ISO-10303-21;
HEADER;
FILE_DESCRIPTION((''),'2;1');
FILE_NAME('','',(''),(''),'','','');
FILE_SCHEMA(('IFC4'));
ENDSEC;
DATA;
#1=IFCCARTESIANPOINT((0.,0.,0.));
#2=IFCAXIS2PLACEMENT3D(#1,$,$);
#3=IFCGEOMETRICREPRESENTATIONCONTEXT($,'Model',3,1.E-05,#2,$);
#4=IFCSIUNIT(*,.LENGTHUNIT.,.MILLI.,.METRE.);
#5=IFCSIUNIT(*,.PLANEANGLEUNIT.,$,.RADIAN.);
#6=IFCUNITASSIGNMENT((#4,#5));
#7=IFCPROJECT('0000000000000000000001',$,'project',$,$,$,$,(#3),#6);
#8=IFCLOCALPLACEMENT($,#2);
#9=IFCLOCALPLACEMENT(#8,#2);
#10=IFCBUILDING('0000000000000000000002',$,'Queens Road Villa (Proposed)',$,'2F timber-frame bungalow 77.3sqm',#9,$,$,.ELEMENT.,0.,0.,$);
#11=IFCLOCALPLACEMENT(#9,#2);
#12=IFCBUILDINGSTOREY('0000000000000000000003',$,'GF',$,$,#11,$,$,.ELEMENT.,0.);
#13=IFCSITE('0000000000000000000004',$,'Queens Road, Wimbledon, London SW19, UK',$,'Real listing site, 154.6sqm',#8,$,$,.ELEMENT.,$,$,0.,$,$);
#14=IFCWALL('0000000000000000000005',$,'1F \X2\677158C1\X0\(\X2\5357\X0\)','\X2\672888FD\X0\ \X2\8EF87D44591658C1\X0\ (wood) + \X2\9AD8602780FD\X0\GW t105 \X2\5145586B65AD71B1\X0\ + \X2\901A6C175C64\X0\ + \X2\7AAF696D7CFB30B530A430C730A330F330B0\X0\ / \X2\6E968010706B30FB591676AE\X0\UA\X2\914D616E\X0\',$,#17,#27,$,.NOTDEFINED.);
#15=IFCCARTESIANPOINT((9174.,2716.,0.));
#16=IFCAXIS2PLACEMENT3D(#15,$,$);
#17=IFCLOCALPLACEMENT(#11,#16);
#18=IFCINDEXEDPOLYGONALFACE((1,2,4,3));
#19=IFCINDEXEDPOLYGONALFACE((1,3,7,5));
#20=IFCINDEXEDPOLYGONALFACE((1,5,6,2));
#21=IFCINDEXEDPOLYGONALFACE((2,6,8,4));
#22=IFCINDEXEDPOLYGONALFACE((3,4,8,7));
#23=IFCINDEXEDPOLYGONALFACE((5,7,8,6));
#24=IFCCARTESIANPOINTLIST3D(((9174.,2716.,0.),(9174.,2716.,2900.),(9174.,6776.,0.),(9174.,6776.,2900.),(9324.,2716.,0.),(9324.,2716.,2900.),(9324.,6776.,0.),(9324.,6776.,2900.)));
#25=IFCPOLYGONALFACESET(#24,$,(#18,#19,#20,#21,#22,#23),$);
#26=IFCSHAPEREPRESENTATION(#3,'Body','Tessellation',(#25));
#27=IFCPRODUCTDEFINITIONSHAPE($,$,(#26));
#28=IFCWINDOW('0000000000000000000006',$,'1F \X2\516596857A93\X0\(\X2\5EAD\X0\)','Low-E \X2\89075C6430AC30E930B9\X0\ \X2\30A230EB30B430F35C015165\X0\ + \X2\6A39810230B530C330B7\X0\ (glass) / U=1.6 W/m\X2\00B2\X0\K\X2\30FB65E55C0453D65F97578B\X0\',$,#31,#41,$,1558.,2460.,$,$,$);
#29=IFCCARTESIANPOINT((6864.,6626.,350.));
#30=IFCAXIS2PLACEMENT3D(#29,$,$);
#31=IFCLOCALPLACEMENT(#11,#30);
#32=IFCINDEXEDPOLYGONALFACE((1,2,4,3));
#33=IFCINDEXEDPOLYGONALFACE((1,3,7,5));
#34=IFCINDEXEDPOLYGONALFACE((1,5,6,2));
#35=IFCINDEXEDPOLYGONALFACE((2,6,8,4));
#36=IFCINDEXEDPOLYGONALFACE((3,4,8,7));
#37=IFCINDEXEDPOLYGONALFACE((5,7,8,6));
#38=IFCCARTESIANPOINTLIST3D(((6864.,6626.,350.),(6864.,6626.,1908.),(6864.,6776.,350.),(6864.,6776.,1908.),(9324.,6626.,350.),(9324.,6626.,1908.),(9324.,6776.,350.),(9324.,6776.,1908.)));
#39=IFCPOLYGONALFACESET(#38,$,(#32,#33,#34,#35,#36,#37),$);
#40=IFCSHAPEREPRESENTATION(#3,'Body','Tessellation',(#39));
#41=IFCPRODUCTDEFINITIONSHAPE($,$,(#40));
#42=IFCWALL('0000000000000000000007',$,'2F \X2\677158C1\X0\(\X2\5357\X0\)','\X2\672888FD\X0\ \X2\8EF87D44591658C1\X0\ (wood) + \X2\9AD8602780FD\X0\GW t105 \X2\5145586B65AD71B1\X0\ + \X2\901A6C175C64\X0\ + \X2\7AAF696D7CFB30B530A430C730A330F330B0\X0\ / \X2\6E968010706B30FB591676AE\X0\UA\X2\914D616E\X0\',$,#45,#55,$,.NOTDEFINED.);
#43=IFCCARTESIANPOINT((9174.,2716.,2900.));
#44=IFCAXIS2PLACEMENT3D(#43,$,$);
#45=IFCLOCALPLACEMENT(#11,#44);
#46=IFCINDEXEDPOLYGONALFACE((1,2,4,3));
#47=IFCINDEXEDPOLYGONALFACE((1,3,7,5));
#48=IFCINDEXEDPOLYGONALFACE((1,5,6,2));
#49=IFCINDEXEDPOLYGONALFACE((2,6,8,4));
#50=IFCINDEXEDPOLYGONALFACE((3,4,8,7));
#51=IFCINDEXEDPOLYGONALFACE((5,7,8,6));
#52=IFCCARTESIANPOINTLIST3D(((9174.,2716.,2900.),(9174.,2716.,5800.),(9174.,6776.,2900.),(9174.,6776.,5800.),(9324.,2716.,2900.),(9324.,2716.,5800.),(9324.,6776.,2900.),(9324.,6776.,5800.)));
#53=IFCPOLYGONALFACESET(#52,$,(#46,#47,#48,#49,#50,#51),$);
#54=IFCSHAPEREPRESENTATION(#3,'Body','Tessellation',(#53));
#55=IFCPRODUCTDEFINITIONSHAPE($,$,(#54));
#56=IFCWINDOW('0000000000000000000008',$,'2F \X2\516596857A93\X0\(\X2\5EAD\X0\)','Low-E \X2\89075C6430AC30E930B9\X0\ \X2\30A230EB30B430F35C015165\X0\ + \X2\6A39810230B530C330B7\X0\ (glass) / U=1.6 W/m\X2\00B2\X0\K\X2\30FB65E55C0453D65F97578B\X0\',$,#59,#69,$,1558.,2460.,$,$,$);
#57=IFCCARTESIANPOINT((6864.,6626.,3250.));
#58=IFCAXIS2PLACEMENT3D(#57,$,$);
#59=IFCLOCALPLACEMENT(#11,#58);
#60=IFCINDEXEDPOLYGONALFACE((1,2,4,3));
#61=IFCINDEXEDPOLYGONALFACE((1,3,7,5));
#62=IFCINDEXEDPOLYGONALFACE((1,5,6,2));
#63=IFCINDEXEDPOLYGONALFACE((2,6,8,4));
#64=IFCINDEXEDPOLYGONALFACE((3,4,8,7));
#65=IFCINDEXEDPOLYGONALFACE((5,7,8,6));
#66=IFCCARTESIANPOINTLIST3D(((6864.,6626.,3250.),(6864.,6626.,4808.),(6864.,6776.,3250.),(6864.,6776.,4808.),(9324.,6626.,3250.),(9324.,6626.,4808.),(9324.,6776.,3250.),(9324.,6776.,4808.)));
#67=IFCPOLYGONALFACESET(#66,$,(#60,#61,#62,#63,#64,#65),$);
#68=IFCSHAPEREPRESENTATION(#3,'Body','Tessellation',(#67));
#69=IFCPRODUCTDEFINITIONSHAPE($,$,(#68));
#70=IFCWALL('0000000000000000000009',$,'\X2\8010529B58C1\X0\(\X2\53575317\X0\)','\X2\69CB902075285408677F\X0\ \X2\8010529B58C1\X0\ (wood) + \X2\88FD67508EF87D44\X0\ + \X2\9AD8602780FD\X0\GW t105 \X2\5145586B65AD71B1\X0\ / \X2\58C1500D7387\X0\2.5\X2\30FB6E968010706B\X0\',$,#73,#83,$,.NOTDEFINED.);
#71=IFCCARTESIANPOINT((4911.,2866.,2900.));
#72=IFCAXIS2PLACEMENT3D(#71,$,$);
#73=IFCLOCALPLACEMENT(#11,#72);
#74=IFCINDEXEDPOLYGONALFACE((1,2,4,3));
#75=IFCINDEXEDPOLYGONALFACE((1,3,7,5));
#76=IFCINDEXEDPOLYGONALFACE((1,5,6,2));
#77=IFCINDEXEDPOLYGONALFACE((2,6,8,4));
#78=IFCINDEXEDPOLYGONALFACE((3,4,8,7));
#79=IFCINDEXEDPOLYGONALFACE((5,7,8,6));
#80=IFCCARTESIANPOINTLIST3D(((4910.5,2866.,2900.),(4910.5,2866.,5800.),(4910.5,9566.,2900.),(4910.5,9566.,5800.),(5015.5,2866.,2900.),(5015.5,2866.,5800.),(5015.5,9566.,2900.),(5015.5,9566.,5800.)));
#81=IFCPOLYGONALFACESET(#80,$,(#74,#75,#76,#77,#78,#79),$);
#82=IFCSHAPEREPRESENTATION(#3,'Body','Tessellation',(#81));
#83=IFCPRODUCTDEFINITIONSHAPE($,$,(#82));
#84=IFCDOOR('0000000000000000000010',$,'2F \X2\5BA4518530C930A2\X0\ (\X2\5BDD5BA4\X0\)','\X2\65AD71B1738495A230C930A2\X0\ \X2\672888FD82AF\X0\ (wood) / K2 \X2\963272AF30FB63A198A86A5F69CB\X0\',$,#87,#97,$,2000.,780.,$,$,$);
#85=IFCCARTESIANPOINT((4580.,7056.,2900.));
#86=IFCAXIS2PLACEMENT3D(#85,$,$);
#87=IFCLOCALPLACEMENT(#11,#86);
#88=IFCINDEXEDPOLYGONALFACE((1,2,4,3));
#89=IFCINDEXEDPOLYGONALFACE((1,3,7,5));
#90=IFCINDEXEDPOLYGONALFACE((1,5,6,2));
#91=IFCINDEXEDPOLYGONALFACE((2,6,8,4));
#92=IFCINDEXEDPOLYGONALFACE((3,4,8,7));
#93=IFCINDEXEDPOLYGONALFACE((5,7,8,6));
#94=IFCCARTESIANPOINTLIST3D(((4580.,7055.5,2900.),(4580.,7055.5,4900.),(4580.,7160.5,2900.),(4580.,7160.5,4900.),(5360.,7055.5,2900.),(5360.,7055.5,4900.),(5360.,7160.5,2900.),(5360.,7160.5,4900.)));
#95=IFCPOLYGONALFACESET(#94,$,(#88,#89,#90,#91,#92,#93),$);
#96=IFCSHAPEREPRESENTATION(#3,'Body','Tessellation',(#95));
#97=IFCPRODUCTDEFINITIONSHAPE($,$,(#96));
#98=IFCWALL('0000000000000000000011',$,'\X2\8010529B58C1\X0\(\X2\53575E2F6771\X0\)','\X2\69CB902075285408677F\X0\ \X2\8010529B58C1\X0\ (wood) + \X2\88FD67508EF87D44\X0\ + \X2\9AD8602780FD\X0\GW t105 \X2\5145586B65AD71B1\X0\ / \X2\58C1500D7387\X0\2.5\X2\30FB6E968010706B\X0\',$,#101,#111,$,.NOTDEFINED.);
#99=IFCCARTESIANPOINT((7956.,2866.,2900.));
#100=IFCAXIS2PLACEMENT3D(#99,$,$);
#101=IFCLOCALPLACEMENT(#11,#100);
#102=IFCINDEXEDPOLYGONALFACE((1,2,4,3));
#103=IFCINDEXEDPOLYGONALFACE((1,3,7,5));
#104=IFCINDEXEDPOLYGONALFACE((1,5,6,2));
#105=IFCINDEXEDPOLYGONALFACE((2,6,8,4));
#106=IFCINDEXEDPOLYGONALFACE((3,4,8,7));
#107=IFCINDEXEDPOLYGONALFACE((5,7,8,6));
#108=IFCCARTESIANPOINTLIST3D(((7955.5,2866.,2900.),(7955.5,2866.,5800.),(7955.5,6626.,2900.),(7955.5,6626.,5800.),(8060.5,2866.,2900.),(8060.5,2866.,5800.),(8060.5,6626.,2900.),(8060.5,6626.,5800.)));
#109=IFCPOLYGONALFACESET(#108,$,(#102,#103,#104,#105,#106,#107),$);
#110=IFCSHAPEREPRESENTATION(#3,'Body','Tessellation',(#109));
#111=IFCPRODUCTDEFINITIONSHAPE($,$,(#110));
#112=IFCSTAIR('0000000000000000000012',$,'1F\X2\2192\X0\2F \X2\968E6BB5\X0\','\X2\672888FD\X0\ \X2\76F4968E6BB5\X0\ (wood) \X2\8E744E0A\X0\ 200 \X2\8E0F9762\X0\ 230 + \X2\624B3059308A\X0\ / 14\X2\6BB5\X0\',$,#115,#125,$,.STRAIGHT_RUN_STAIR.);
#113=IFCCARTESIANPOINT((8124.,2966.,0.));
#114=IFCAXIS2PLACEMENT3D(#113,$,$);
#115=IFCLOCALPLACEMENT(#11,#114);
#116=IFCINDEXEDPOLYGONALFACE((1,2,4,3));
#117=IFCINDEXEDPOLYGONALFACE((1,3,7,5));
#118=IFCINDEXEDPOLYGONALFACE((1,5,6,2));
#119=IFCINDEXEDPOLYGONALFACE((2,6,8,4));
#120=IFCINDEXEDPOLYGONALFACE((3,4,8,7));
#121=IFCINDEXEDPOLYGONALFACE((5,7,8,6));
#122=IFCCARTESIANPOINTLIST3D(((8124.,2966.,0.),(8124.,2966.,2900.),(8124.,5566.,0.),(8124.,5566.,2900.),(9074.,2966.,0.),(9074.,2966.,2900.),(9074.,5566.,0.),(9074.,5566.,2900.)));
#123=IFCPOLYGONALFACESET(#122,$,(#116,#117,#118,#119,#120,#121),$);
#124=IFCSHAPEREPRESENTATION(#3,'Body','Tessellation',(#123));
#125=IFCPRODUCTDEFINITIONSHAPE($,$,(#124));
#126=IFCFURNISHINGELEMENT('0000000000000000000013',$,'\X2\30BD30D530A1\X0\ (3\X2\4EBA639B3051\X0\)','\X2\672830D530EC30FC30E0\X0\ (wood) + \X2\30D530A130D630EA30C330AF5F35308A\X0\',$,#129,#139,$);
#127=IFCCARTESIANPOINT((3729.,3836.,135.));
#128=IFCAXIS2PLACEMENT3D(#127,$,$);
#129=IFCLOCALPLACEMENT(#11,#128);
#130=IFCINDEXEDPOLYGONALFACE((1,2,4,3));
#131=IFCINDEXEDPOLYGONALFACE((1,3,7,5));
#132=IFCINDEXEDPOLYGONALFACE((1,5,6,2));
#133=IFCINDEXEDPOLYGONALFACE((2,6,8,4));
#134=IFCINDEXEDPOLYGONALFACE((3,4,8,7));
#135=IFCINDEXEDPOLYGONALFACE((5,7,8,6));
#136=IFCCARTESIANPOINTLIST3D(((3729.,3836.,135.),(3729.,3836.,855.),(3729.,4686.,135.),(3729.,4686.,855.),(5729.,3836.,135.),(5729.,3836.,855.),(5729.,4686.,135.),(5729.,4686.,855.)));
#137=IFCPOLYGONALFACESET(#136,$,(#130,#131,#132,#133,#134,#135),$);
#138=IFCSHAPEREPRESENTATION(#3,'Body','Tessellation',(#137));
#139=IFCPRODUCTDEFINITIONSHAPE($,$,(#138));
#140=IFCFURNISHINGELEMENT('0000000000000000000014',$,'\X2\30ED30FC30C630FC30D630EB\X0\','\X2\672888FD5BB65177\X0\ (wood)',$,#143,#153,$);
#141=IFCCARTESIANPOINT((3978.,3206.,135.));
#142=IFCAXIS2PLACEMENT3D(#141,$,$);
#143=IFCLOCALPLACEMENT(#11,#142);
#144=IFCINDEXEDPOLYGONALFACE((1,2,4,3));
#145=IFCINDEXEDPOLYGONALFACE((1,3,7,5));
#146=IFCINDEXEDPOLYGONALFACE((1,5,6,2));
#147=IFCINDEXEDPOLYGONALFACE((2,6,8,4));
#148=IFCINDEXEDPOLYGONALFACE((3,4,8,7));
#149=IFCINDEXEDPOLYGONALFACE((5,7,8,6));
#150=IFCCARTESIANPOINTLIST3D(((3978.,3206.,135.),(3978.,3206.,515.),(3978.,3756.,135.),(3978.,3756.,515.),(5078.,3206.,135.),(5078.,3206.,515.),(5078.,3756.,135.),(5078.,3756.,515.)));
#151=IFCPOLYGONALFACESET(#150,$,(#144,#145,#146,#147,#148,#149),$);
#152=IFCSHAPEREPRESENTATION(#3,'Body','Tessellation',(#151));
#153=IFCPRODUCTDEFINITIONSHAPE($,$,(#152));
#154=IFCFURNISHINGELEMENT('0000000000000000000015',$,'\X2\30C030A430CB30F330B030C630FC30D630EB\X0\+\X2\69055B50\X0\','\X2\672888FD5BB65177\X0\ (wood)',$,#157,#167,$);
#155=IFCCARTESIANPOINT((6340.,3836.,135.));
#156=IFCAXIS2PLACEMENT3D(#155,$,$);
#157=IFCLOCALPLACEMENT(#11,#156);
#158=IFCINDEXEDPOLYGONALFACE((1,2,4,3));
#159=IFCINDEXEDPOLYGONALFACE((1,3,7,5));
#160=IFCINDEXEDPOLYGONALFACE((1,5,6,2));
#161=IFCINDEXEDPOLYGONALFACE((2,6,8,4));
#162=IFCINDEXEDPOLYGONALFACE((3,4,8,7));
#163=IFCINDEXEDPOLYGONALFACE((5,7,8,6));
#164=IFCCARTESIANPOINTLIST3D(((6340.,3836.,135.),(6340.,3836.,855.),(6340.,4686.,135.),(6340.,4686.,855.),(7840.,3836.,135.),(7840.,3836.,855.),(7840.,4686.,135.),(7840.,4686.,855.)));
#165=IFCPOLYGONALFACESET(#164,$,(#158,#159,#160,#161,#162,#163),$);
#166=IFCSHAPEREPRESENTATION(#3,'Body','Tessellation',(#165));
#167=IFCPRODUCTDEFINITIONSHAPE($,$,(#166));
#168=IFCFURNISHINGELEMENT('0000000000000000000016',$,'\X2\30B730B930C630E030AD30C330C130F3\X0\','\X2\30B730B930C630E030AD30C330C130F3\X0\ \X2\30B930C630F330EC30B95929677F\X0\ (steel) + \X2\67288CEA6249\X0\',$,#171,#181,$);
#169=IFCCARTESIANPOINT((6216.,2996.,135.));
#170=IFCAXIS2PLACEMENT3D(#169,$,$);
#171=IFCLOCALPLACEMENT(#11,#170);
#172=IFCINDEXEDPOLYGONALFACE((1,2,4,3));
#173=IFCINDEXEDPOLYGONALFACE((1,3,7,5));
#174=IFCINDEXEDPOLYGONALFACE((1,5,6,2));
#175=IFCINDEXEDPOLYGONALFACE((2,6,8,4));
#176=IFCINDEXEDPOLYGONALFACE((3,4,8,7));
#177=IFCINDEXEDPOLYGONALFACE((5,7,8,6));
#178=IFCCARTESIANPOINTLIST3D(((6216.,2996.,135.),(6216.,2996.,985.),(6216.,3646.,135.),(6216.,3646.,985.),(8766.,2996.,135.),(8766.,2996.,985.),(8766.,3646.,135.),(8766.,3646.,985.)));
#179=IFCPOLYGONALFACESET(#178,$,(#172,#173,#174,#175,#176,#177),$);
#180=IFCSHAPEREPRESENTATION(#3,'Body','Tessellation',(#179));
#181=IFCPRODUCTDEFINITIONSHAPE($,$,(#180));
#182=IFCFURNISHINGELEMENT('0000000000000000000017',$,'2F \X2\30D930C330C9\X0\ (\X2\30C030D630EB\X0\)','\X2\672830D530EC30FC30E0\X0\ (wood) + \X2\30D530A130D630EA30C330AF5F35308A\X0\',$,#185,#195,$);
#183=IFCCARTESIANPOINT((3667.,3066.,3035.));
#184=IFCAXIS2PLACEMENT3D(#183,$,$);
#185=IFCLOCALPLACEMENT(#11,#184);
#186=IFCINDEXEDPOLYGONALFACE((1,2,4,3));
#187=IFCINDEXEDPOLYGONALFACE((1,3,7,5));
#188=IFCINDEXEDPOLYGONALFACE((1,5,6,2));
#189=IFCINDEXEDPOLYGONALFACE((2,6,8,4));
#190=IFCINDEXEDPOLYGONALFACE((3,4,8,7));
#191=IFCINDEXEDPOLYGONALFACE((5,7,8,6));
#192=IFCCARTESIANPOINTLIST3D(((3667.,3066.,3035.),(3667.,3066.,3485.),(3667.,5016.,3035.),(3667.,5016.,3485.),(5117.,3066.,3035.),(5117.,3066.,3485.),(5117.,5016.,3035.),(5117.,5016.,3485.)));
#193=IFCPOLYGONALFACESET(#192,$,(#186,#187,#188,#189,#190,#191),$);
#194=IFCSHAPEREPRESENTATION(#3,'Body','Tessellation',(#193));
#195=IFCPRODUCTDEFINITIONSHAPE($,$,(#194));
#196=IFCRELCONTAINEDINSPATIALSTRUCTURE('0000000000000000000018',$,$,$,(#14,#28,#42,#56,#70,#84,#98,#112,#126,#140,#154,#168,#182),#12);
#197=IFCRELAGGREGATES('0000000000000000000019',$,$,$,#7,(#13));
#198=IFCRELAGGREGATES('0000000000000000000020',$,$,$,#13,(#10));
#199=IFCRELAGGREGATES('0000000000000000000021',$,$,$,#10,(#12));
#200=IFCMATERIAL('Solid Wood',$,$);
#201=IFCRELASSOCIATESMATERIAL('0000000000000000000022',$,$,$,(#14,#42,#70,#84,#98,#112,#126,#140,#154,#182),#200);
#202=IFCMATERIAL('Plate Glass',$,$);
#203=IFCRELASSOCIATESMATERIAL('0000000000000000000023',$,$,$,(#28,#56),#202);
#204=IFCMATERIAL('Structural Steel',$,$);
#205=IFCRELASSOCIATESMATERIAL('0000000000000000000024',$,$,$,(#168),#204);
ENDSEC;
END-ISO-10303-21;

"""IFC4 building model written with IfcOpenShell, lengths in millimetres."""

from ifc_helpers import new_model, si_unit, frame, frame_2d, origin, place, context, project, spatial, rectangle, extrude, material, element, fill, save


model = new_model("IFC4")

# Units and contexts
model_context = context("Model", 3, precision=1e-05, world=origin())
ifc_project = project(units=[si_unit("LENGTHUNIT", "METRE", prefix="MILLI"), si_unit("PLANEANGLEUNIT", "RADIAN")], contexts=[model_context])

# Site, building, storey
site_placement = place(None, origin())
site = spatial("IfcSite", under=ifc_project, at=site_placement, Name="Queens Road, Wimbledon, London SW19, UK", ObjectType="Real listing site, 154.6sqm", CompositionType="ELEMENT", RefElevation=0.0)
building_placement = place(site_placement, origin())
building = spatial("IfcBuilding", under=site, at=building_placement, Name="Queens Road Villa (Proposed)", ObjectType="2F timber-frame bungalow 77.3sqm", CompositionType="ELEMENT", ElevationOfRefHeight=0.0, ElevationOfTerrain=0.0)
storey_placement = place(building_placement, origin())
storey = spatial("IfcBuildingStorey", under=building, at=storey_placement, Name="GF", CompositionType="ELEMENT", Elevation=0.0)

# Wall, opening, window
ifc_material_1 = material(Name="Solid Wood")
wall_1_placement = place(storey_placement, frame((9174.0, 2716.0, 0.0)))
wall_1 = element("IfcWall", 1, at=wall_1_placement, inside=storey, material=ifc_material_1, Name="1F 東壁(南)", Description="木製 軸組外壁 (wood) + 高性能GW t105 充填断熱 + 通気層 + 窯業系サイディング / 準耐火・外皮UA配慮", PredefinedType="NOTDEFINED", context=model_context, shape_type="SweptSolid", body=[
    extrude(rectangle(XDim=150.0, YDim=4060.0, at=frame_2d((75.0, 2030.0))), frame((9174.0, 2716.0, 0.0)), (0.0, 0.0, 1.0), 2900.0),
])
opening_1_placement = place(storey_placement, frame((6864.0, 6626.0, 350.0)))
opening_1 = element("IfcOpeningElement", 2, at=opening_1_placement, cuts=wall_1, PredefinedType="NOTDEFINED", context=model_context, shape_type="SweptSolid", body=[
    extrude(rectangle(XDim=2460.0, YDim=150.0, at=frame_2d((1230.0, 75.0))), frame((6864.0, 6626.0, 350.0)), (0.0, 0.0, 1.0), 1558.0),
])
ifc_material_2 = material(Name="Plate Glass")
window_1_placement = place(storey_placement, frame((6864.0, 6626.0, 350.0)))
window_1 = element("IfcWindow", 3, at=window_1_placement, inside=storey, material=ifc_material_2, Name="1F 入隅窓(庭)", Description="Low-E 複層ガラス アルゴン封入 + 樹脂サッシ (glass) / U=1.6 W/m²K・日射取得型", OverallHeight=1558.0, OverallWidth=2460.0, context=model_context, shape_type="SweptSolid", body=[
    extrude(rectangle(XDim=2460.0, YDim=150.0, at=frame_2d((1230.0, 75.0))), frame((6864.0, 6626.0, 350.0)), (0.0, 0.0, 1.0), 1558.0),
])
fill(opening_1, window_1)

# Wall, opening, window
wall_2_placement = place(storey_placement, frame((9174.0, 2716.0, 2900.0)))
wall_2 = element("IfcWall", 4, at=wall_2_placement, inside=storey, material=ifc_material_1, Name="2F 東壁(南)", Description="木製 軸組外壁 (wood) + 高性能GW t105 充填断熱 + 通気層 + 窯業系サイディング / 準耐火・外皮UA配慮", PredefinedType="NOTDEFINED", context=model_context, shape_type="SweptSolid", body=[
    extrude(rectangle(XDim=150.0, YDim=4060.0, at=frame_2d((75.0, 2030.0))), frame((9174.0, 2716.0, 2900.0)), (0.0, 0.0, 1.0), 2900.0),
])
opening_2_placement = place(storey_placement, frame((6864.0, 6626.0, 3250.0)))
opening_2 = element("IfcOpeningElement", 5, at=opening_2_placement, cuts=wall_2, PredefinedType="NOTDEFINED", context=model_context, shape_type="SweptSolid", body=[
    extrude(rectangle(XDim=2460.0, YDim=150.0, at=frame_2d((1230.0, 75.0))), frame((6864.0, 6626.0, 3250.0)), (0.0, 0.0, 1.0), 1558.0),
])
window_2_placement = place(storey_placement, frame((6864.0, 6626.0, 3250.0)))
window_2 = element("IfcWindow", 6, at=window_2_placement, inside=storey, material=ifc_material_2, Name="2F 入隅窓(庭)", Description="Low-E 複層ガラス アルゴン封入 + 樹脂サッシ (glass) / U=1.6 W/m²K・日射取得型", OverallHeight=1558.0, OverallWidth=2460.0, context=model_context, shape_type="SweptSolid", body=[
    extrude(rectangle(XDim=2460.0, YDim=150.0, at=frame_2d((1230.0, 75.0))), frame((6864.0, 6626.0, 3250.0)), (0.0, 0.0, 1.0), 1558.0),
])
fill(opening_2, window_2)

# Wall, opening, door
wall_3_placement = place(storey_placement, frame((4911.0, 2866.0, 2900.0)))
wall_3 = element("IfcWall", 7, at=wall_3_placement, inside=storey, material=ifc_material_1, Name="耐力壁(南北)", Description="構造用合板 耐力壁 (wood) + 製材軸組 + 高性能GW t105 充填断熱 / 壁倍率2.5・準耐火", PredefinedType="NOTDEFINED", context=model_context, shape_type="SweptSolid", body=[
    extrude(rectangle(XDim=105.0, YDim=6700.0, at=frame_2d((52.0, 3350.0))), frame((4911.0, 2866.0, 2900.0)), (0.0, 0.0, 1.0), 2900.0),
])
opening_3_placement = place(storey_placement, frame((4580.0, 7056.0, 2900.0)))
opening_3 = element("IfcOpeningElement", 8, at=opening_3_placement, cuts=wall_3, PredefinedType="NOTDEFINED", context=model_context, shape_type="SweptSolid", body=[
    extrude(rectangle(XDim=780.0, YDim=105.0, at=frame_2d((390.0, 52.0))), frame((4580.0, 7056.0, 2900.0)), (0.0, 0.0, 1.0), 2000.0),
])
door_1_placement = place(storey_placement, frame((4580.0, 7056.0, 2900.0)))
door_1 = element("IfcDoor", 9, at=door_1_placement, inside=storey, material=ifc_material_1, Name="2F 室内ドア (寝室)", Description="断熱玄関ドア 木製芯 (wood) / K2 防犯・採風機構", OverallHeight=2000.0, OverallWidth=780.0, context=model_context, shape_type="SweptSolid", body=[
    extrude(rectangle(XDim=780.0, YDim=105.0, at=frame_2d((390.0, 52.0))), frame((4580.0, 7056.0, 2900.0)), (0.0, 0.0, 1.0), 2000.0),
])
fill(opening_3, door_1)

# Wall
wall_4_placement = place(storey_placement, frame((7956.0, 2866.0, 2900.0)))
element("IfcWall", 10, at=wall_4_placement, inside=storey, material=ifc_material_1, Name="耐力壁(南帯東)", Description="構造用合板 耐力壁 (wood) + 製材軸組 + 高性能GW t105 充填断熱 / 壁倍率2.5・準耐火", PredefinedType="NOTDEFINED", context=model_context, shape_type="SweptSolid", body=[
    extrude(rectangle(XDim=105.0, YDim=3760.0, at=frame_2d((52.0, 1880.0))), frame((7956.0, 2866.0, 2900.0)), (0.0, 0.0, 1.0), 2900.0),
])

# Stair
stair_placement = place(storey_placement, frame((8124.0, 2966.0, 0.0)))
element("IfcStair", 11, at=stair_placement, inside=storey, material=ifc_material_1, Name="1F→2F 階段", Description="木製 直階段 (wood) 蹴上 200 踏面 230 + 手すり / 14段", PredefinedType="STRAIGHT_RUN_STAIR", context=model_context, shape_type="SweptSolid", body=[
    extrude(rectangle(XDim=950.0, YDim=2600.0, at=frame_2d((475.0, 1300.0))), frame((8124.0, 2966.0, 0.0)), (0.0, 0.0, 1.0), 2900.0),
])

# Furnishing elements
furnishing_1_placement = place(storey_placement, frame((3729.0, 3836.0, 135.0)))
element("IfcFurnishingElement", 12, at=furnishing_1_placement, inside=storey, material=ifc_material_1, Name="ソファ (3人掛け)", Description="木フレーム (wood) + ファブリック張り", context=model_context, shape_type="SweptSolid", body=[
    extrude(rectangle(XDim=2000.0, YDim=850.0, at=frame_2d((1000.0, 425.0))), frame((3729.0, 3836.0, 135.0)), (0.0, 0.0, 1.0), 720.0),
])
furnishing_2_placement = place(storey_placement, frame((3978.0, 3206.0, 135.0)))
element("IfcFurnishingElement", 13, at=furnishing_2_placement, inside=storey, material=ifc_material_1, Name="ローテーブル", Description="木製家具 (wood)", context=model_context, shape_type="SweptSolid", body=[
    extrude(rectangle(XDim=1100.0, YDim=550.0, at=frame_2d((550.0, 275.0))), frame((3978.0, 3206.0, 135.0)), (0.0, 0.0, 1.0), 380.0),
])
furnishing_3_placement = place(storey_placement, frame((6340.0, 3836.0, 135.0)))
element("IfcFurnishingElement", 14, at=furnishing_3_placement, inside=storey, material=ifc_material_1, Name="ダイニングテーブル+椅子", Description="木製家具 (wood)", context=model_context, shape_type="SweptSolid", body=[
    extrude(rectangle(XDim=1500.0, YDim=850.0, at=frame_2d((750.0, 425.0))), frame((6340.0, 3836.0, 135.0)), (0.0, 0.0, 1.0), 720.0),
])
ifc_material_3 = material(Name="Structural Steel")
furnishing_4_placement = place(storey_placement, frame((6216.0, 2996.0, 135.0)))
element("IfcFurnishingElement", 15, at=furnishing_4_placement, inside=storey, material=ifc_material_3, Name="システムキッチン", Description="システムキッチン ステンレス天板 (steel) + 木質扉", context=model_context, shape_type="SweptSolid", body=[
    extrude(rectangle(XDim=2550.0, YDim=650.0, at=frame_2d((1275.0, 325.0))), frame((6216.0, 2996.0, 135.0)), (0.0, 0.0, 1.0), 850.0),
])
furnishing_5_placement = place(storey_placement, frame((3667.0, 3066.0, 3035.0)))
element("IfcFurnishingElement", 16, at=furnishing_5_placement, inside=storey, material=ifc_material_1, Name="2F ベッド (ダブル)", Description="木フレーム (wood) + ファブリック張り", context=model_context, shape_type="SweptSolid", body=[
    extrude(rectangle(XDim=1450.0, YDim=1950.0, at=frame_2d((725.0, 975.0))), frame((3667.0, 3066.0, 3035.0)), (0.0, 0.0, 1.0), 450.0),
])

save(model, "model.ifc")
